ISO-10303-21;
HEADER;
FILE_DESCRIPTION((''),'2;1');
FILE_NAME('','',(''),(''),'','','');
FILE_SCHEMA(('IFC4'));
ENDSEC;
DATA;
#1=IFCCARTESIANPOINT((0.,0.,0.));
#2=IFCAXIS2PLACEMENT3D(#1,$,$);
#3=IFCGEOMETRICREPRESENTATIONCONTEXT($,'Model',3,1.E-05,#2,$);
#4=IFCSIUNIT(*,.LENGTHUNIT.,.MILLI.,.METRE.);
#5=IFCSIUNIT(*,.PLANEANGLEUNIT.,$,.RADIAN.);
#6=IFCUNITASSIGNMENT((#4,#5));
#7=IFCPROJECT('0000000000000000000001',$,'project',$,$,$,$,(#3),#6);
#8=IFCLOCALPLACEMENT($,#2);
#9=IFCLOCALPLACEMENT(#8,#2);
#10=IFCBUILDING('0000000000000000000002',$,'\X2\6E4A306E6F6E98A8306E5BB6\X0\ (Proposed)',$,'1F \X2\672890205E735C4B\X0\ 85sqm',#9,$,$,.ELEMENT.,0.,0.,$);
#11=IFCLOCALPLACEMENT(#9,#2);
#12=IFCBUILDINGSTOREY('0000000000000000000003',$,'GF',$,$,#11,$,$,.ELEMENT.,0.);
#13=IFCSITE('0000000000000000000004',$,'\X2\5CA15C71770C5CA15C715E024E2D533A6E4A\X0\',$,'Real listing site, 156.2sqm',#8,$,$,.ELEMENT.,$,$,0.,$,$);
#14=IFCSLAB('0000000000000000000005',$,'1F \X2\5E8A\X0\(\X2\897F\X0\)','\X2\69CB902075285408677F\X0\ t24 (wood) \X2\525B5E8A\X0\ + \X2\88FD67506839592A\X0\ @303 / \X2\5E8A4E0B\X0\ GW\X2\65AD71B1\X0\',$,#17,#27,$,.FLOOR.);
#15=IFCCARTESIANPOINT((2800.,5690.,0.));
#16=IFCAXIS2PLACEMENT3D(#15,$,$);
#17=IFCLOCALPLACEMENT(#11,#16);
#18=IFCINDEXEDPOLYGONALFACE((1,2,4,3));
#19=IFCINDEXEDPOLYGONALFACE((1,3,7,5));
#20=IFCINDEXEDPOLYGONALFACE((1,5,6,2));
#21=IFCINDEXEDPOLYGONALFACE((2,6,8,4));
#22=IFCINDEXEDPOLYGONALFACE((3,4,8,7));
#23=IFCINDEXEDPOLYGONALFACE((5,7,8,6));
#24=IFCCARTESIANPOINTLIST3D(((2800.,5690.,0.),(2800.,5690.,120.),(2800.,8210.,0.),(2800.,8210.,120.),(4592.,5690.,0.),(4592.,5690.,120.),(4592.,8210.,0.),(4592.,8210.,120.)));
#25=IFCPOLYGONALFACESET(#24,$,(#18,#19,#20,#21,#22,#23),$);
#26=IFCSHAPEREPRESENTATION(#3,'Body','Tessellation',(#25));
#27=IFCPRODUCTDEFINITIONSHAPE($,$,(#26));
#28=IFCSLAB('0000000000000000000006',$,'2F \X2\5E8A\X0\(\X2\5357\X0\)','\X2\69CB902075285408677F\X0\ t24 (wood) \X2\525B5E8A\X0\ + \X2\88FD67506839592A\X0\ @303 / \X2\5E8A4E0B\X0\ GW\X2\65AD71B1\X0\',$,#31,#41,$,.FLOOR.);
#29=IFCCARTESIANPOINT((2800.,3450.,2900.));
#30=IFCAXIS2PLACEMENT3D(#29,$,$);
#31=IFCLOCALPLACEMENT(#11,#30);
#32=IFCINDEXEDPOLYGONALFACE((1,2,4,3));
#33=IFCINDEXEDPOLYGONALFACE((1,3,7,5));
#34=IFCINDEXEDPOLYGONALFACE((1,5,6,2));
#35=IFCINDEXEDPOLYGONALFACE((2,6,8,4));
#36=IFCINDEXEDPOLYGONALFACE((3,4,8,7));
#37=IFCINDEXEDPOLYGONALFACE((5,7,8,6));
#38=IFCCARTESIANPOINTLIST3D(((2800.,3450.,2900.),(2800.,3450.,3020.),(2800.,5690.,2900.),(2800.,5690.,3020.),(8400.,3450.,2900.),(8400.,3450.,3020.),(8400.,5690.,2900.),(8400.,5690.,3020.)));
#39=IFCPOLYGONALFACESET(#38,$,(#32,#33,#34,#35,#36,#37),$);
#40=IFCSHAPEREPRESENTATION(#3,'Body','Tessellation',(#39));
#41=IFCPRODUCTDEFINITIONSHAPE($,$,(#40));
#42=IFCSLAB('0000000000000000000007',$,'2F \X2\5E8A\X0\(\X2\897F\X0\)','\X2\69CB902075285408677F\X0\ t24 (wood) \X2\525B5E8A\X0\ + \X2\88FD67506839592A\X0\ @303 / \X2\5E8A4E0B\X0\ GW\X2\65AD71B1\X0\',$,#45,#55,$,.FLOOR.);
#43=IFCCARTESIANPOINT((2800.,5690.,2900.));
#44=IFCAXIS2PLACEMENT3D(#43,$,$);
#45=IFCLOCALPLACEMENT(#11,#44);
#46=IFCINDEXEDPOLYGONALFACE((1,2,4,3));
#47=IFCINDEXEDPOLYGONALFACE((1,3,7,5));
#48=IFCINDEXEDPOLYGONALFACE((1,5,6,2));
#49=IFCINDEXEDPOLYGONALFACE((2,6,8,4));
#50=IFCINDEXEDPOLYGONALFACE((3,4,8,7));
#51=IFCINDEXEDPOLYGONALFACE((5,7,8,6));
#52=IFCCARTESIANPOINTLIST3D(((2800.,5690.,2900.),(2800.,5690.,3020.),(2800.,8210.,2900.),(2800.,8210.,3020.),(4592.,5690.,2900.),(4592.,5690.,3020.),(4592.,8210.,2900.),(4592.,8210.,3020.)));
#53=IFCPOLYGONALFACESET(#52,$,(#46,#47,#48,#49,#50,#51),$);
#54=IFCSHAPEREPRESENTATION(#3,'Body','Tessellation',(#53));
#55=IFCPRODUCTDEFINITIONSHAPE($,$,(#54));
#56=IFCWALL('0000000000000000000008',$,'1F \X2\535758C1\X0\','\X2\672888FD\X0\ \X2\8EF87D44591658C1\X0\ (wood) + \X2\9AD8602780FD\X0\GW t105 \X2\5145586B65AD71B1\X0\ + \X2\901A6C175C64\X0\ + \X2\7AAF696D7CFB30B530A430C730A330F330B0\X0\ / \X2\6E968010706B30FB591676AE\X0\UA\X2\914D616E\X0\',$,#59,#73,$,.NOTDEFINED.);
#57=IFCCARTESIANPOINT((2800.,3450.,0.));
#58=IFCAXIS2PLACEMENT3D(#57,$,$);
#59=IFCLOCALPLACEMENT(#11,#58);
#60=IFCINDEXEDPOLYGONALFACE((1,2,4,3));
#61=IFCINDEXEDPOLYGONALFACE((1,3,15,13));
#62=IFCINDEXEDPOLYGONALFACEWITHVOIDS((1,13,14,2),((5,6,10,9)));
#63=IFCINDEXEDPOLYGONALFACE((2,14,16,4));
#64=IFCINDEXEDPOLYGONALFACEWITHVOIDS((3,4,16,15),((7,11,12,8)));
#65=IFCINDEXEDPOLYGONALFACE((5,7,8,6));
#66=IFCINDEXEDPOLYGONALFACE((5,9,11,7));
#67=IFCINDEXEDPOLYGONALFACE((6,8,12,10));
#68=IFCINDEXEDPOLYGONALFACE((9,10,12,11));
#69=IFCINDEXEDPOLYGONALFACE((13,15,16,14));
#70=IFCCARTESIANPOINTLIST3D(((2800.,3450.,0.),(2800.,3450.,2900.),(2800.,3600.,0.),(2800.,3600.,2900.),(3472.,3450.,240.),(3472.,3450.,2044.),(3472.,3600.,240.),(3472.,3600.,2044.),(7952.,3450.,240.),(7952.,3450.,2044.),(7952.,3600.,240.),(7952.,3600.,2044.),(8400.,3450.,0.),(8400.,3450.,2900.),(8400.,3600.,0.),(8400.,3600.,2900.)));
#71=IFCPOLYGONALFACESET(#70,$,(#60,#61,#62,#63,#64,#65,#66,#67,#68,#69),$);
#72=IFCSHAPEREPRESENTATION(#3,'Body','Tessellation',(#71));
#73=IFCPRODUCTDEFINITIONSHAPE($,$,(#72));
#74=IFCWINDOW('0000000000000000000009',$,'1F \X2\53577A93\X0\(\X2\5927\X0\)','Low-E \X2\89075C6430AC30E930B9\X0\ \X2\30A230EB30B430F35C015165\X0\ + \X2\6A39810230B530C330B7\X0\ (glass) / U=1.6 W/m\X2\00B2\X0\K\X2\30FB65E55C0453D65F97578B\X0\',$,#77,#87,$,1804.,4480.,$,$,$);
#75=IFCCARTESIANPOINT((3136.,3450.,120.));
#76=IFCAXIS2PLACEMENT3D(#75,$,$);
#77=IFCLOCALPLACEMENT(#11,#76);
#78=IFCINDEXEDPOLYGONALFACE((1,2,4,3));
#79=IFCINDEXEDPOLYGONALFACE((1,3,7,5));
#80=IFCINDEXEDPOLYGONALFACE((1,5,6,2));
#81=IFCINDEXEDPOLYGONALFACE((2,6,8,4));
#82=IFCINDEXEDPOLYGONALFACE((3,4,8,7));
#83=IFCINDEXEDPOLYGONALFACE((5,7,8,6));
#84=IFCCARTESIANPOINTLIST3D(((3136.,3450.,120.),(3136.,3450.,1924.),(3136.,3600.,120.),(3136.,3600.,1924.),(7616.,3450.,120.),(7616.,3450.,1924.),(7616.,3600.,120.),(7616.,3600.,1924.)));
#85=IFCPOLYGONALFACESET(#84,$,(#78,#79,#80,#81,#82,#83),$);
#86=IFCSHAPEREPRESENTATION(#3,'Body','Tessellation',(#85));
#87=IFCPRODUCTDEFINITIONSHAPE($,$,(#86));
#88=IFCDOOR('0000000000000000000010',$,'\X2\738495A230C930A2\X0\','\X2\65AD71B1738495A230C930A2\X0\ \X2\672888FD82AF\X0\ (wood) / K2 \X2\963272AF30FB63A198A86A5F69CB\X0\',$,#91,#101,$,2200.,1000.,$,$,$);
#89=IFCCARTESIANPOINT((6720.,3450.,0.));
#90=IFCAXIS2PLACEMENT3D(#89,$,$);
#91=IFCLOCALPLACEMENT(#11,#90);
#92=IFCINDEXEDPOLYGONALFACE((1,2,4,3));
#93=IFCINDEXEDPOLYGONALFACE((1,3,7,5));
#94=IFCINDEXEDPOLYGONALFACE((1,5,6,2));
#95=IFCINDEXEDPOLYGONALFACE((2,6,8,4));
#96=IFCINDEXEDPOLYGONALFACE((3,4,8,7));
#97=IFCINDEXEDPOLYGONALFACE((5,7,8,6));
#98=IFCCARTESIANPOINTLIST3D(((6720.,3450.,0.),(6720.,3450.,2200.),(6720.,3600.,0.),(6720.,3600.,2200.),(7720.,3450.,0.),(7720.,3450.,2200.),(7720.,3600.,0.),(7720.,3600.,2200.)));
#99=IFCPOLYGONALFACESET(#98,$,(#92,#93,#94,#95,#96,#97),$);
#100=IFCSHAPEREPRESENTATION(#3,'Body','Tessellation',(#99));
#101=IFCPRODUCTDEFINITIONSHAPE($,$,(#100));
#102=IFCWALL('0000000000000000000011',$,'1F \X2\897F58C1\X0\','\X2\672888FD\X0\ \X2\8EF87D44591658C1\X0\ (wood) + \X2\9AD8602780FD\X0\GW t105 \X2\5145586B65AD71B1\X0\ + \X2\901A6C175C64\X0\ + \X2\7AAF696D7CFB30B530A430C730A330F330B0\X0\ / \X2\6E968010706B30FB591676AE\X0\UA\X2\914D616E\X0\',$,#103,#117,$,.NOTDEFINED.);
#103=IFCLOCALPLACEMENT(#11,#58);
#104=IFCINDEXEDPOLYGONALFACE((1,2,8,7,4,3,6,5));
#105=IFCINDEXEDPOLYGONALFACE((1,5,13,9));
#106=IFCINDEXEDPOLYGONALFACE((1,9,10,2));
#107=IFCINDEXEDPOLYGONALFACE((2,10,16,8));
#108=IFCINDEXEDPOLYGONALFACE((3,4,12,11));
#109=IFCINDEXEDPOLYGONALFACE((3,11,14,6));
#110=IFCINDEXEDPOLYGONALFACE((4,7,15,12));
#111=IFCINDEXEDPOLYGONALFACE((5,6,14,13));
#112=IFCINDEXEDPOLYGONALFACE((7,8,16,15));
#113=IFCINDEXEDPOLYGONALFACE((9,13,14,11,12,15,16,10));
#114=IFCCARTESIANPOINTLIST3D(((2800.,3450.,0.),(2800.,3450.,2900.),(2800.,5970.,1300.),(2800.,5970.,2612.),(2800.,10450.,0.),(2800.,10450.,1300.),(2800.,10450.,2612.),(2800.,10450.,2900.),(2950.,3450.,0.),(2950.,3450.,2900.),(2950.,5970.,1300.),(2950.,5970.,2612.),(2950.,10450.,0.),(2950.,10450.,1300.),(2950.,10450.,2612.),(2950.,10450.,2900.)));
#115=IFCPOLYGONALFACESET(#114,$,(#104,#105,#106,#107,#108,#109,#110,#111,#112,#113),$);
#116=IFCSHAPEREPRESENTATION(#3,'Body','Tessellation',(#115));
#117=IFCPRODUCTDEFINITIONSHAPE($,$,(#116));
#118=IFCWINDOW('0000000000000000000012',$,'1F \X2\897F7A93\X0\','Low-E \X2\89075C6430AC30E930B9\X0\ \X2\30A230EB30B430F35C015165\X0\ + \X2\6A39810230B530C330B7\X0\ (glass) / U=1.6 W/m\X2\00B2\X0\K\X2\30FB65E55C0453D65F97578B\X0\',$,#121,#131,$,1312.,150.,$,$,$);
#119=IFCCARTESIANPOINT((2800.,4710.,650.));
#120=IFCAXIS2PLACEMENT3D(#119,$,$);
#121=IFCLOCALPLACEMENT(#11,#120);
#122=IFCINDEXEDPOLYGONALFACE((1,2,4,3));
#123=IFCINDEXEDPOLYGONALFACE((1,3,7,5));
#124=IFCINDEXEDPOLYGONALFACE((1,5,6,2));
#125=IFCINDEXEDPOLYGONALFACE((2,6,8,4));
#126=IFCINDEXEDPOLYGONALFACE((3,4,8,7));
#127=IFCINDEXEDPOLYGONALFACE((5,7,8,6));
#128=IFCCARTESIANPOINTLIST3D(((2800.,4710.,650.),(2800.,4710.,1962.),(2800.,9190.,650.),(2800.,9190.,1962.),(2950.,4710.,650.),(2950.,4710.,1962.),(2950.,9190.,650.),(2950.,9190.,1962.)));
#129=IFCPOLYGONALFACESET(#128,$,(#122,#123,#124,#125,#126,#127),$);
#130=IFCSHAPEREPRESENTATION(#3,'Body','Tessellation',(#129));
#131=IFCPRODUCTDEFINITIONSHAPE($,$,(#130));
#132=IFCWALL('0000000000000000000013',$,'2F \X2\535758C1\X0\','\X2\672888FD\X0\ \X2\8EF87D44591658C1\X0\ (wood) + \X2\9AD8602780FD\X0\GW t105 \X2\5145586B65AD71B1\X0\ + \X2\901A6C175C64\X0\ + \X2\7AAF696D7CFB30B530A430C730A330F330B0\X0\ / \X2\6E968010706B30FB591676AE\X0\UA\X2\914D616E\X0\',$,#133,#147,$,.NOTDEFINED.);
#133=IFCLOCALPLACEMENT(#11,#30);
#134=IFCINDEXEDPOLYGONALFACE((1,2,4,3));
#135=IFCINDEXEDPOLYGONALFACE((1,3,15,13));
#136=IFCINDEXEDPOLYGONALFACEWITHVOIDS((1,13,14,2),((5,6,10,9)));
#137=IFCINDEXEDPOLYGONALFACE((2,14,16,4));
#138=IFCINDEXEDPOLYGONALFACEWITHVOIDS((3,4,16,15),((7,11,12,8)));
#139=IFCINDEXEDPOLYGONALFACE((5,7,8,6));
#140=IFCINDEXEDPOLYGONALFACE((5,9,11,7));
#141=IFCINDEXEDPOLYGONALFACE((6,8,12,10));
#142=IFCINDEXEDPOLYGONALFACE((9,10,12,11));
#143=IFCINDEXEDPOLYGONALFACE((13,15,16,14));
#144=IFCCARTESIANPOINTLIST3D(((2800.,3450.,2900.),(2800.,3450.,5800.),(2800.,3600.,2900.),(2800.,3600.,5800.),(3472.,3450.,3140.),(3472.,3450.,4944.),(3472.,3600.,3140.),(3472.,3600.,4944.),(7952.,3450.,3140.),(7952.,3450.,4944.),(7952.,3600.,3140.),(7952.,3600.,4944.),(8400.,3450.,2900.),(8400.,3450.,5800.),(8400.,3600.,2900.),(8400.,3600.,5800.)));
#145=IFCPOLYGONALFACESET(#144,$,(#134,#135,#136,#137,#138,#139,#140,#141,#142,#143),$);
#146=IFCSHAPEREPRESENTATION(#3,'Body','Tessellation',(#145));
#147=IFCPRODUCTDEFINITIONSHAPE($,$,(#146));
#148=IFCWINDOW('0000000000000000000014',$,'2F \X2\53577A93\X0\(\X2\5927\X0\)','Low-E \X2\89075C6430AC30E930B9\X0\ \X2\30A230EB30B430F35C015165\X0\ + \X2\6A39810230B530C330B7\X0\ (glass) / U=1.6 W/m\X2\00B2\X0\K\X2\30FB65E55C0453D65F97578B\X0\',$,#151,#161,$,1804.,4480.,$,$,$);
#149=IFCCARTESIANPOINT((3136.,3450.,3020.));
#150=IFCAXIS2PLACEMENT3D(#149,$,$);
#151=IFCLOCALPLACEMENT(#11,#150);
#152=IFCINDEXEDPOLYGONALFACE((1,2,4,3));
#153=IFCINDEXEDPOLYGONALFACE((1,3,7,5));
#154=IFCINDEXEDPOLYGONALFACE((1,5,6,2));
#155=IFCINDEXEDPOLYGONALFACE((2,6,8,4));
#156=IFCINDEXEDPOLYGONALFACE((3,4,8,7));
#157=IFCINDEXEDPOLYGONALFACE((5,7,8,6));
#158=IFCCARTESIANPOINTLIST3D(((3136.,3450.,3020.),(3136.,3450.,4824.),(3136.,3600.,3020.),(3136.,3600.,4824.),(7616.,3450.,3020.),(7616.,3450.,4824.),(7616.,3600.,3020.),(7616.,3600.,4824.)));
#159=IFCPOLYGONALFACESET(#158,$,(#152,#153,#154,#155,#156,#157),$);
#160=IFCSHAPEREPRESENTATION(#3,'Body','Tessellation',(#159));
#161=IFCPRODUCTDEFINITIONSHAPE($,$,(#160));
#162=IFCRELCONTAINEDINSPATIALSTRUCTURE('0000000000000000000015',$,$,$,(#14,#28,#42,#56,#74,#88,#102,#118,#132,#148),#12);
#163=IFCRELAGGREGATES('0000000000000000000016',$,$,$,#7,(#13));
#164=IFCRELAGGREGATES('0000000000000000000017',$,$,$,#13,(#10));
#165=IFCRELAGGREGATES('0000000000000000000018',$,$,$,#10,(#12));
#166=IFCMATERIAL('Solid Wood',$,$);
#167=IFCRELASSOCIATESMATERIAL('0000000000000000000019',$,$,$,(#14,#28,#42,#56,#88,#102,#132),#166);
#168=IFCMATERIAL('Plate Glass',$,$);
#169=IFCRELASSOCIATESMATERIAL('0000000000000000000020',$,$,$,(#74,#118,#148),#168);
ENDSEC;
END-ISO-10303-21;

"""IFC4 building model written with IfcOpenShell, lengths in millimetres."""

from ifc_helpers import new_model, si_unit, frame, frame_2d, origin, place, context, project, spatial, rectangle, extrude, material, element, fill, save


model = new_model("IFC4")

# Units and contexts
model_context = context("Model", 3, precision=1e-05, world=origin())
ifc_project = project(units=[si_unit("LENGTHUNIT", "METRE", prefix="MILLI"), si_unit("PLANEANGLEUNIT", "RADIAN")], contexts=[model_context])

# Site, building, storey
site_placement = place(None, origin())
site = spatial("IfcSite", under=ifc_project, at=site_placement, Name="岡山県岡山市中区湊", ObjectType="Real listing site, 156.2sqm", CompositionType="ELEMENT", RefElevation=0.0)
building_placement = place(site_placement, origin())
building = spatial("IfcBuilding", under=site, at=building_placement, Name="湊の潮風の家 (Proposed)", ObjectType="1F 木造平屋 85sqm", CompositionType="ELEMENT", ElevationOfRefHeight=0.0, ElevationOfTerrain=0.0)
storey_placement = place(building_placement, origin())
storey = spatial("IfcBuildingStorey", under=building, at=storey_placement, Name="GF", CompositionType="ELEMENT", Elevation=0.0)

# Slabs
ifc_material_1 = material(Name="Solid Wood")
slab_1_placement = place(storey_placement, frame((2800.0, 5690.0, 0.0)))
element("IfcSlab", 1, at=slab_1_placement, inside=storey, material=ifc_material_1, Name="1F 床(西)", Description="構造用合板 t24 (wood) 剛床 + 製材根太 @303 / 床下 GW断熱", PredefinedType="FLOOR", context=model_context, shape_type="SweptSolid", body=[
    extrude(rectangle(XDim=1792.0, YDim=2520.0, at=frame_2d((896.0, 1260.0))), frame((2800.0, 5690.0, 0.0)), (0.0, 0.0, 1.0), 120.0),
])
slab_2_placement = place(storey_placement, frame((2800.0, 3450.0, 2900.0)))
element("IfcSlab", 2, at=slab_2_placement, inside=storey, material=ifc_material_1, Name="2F 床(南)", Description="構造用合板 t24 (wood) 剛床 + 製材根太 @303 / 床下 GW断熱", PredefinedType="FLOOR", context=model_context, shape_type="SweptSolid", body=[
    extrude(rectangle(XDim=5600.0, YDim=2240.0, at=frame_2d((2800.0, 1120.0))), frame((2800.0, 3450.0, 2900.0)), (0.0, 0.0, 1.0), 120.0),
])
slab_3_placement = place(storey_placement, frame((2800.0, 5690.0, 2900.0)))
element("IfcSlab", 3, at=slab_3_placement, inside=storey, material=ifc_material_1, Name="2F 床(西)", Description="構造用合板 t24 (wood) 剛床 + 製材根太 @303 / 床下 GW断熱", PredefinedType="FLOOR", context=model_context, shape_type="SweptSolid", body=[
    extrude(rectangle(XDim=1792.0, YDim=2520.0, at=frame_2d((896.0, 1260.0))), frame((2800.0, 5690.0, 2900.0)), (0.0, 0.0, 1.0), 120.0),
])

# Wall, openings, window, door
wall_1_placement = place(storey_placement, frame((2800.0, 3450.0, 0.0)))
wall_1 = element("IfcWall", 4, at=wall_1_placement, inside=storey, material=ifc_material_1, Name="1F 南壁", Description="木製 軸組外壁 (wood) + 高性能GW t105 充填断熱 + 通気層 + 窯業系サイディング / 準耐火・外皮UA配慮", PredefinedType="NOTDEFINED", context=model_context, shape_type="SweptSolid", body=[
    extrude(rectangle(XDim=5600.0, YDim=150.0, at=frame_2d((2800.0, 75.0))), frame((2800.0, 3450.0, 0.0)), (0.0, 0.0, 1.0), 2900.0),
])
opening_1_placement = place(storey_placement, frame((3136.0, 3450.0, 120.0)))
opening_1 = element("IfcOpeningElement", 5, at=opening_1_placement, cuts=wall_1, PredefinedType="NOTDEFINED", context=model_context, shape_type="SweptSolid", body=[
    extrude(rectangle(XDim=4480.0, YDim=150.0, at=frame_2d((2240.0, 75.0))), frame((3136.0, 3450.0, 120.0)), (0.0, 0.0, 1.0), 1804.0),
])
opening_2_placement = place(storey_placement, frame((6720.0, 3450.0, 0.0)))
opening_2 = element("IfcOpeningElement", 6, at=opening_2_placement, cuts=wall_1, PredefinedType="NOTDEFINED", context=model_context, shape_type="SweptSolid", body=[
    extrude(rectangle(XDim=1000.0, YDim=150.0, at=frame_2d((500.0, 75.0))), frame((6720.0, 3450.0, 0.0)), (0.0, 0.0, 1.0), 2200.0),
])
ifc_material_2 = material(Name="Plate Glass")
window_1_placement = place(storey_placement, frame((3136.0, 3450.0, 120.0)))
window_1 = element("IfcWindow", 7, at=window_1_placement, inside=storey, material=ifc_material_2, Name="1F 南窓(大)", Description="Low-E 複層ガラス アルゴン封入 + 樹脂サッシ (glass) / U=1.6 W/m²K・日射取得型", OverallHeight=1804.0, OverallWidth=4480.0, context=model_context, shape_type="SweptSolid", body=[
    extrude(rectangle(XDim=4480.0, YDim=150.0, at=frame_2d((2240.0, 75.0))), frame((3136.0, 3450.0, 120.0)), (0.0, 0.0, 1.0), 1804.0),
])
fill(opening_1, window_1)
door_placement = place(storey_placement, frame((6720.0, 3450.0, 0.0)))
door = element("IfcDoor", 8, at=door_placement, inside=storey, material=ifc_material_1, Name="玄関ドア", Description="断熱玄関ドア 木製芯 (wood) / K2 防犯・採風機構", OverallHeight=2200.0, OverallWidth=1000.0, context=model_context, shape_type="SweptSolid", body=[
    extrude(rectangle(XDim=1000.0, YDim=150.0, at=frame_2d((500.0, 75.0))), frame((6720.0, 3450.0, 0.0)), (0.0, 0.0, 1.0), 2200.0),
])
fill(opening_2, door)

# Walls, openings, windows
wall_2_placement = place(storey_placement, frame((2800.0, 3450.0, 0.0)))
wall_2 = element("IfcWall", 9, at=wall_2_placement, inside=storey, material=ifc_material_1, Name="1F 西壁", Description="木製 軸組外壁 (wood) + 高性能GW t105 充填断熱 + 通気層 + 窯業系サイディング / 準耐火・外皮UA配慮", PredefinedType="NOTDEFINED", context=model_context, shape_type="SweptSolid", body=[
    extrude(rectangle(XDim=150.0, YDim=7000.0, at=frame_2d((75.0, 3500.0))), frame((2800.0, 3450.0, 0.0)), (0.0, 0.0, 1.0), 2900.0),
])
opening_3_placement = place(storey_placement, frame((2800.0, 4710.0, 650.0)))
opening_3 = element("IfcOpeningElement", 10, at=opening_3_placement, cuts=wall_2, PredefinedType="NOTDEFINED", context=model_context, shape_type="SweptSolid", body=[
    extrude(rectangle(XDim=150.0, YDim=4480.0, at=frame_2d((75.0, 2240.0))), frame((2800.0, 4710.0, 650.0)), (0.0, 0.0, 1.0), 1312.0),
])
window_2_placement = place(storey_placement, frame((2800.0, 4710.0, 650.0)))
window_2 = element("IfcWindow", 11, at=window_2_placement, inside=storey, material=ifc_material_2, Name="1F 西窓", Description="Low-E 複層ガラス アルゴン封入 + 樹脂サッシ (glass) / U=1.6 W/m²K・日射取得型", OverallHeight=1312.0, OverallWidth=150.0, context=model_context, shape_type="SweptSolid", body=[
    extrude(rectangle(XDim=150.0, YDim=4480.0, at=frame_2d((75.0, 2240.0))), frame((2800.0, 4710.0, 650.0)), (0.0, 0.0, 1.0), 1312.0),
])
fill(opening_3, window_2)
wall_3_placement = place(storey_placement, frame((2800.0, 3450.0, 2900.0)))
wall_3 = element("IfcWall", 12, at=wall_3_placement, inside=storey, material=ifc_material_1, Name="2F 南壁", Description="木製 軸組外壁 (wood) + 高性能GW t105 充填断熱 + 通気層 + 窯業系サイディング / 準耐火・外皮UA配慮", PredefinedType="NOTDEFINED", context=model_context, shape_type="SweptSolid", body=[
    extrude(rectangle(XDim=5600.0, YDim=150.0, at=frame_2d((2800.0, 75.0))), frame((2800.0, 3450.0, 2900.0)), (0.0, 0.0, 1.0), 2900.0),
])
opening_4_placement = place(storey_placement, frame((3136.0, 3450.0, 3020.0)))
opening_4 = element("IfcOpeningElement", 13, at=opening_4_placement, cuts=wall_3, PredefinedType="NOTDEFINED", context=model_context, shape_type="SweptSolid", body=[
    extrude(rectangle(XDim=4480.0, YDim=150.0, at=frame_2d((2240.0, 75.0))), frame((3136.0, 3450.0, 3020.0)), (0.0, 0.0, 1.0), 1804.0),
])
window_3_placement = place(storey_placement, frame((3136.0, 3450.0, 3020.0)))
window_3 = element("IfcWindow", 14, at=window_3_placement, inside=storey, material=ifc_material_2, Name="2F 南窓(大)", Description="Low-E 複層ガラス アルゴン封入 + 樹脂サッシ (glass) / U=1.6 W/m²K・日射取得型", OverallHeight=1804.0, OverallWidth=4480.0, context=model_context, shape_type="SweptSolid", body=[
    extrude(rectangle(XDim=4480.0, YDim=150.0, at=frame_2d((2240.0, 75.0))), frame((3136.0, 3450.0, 3020.0)), (0.0, 0.0, 1.0), 1804.0),
])
fill(opening_4, window_3)

save(model, "model.ifc")
